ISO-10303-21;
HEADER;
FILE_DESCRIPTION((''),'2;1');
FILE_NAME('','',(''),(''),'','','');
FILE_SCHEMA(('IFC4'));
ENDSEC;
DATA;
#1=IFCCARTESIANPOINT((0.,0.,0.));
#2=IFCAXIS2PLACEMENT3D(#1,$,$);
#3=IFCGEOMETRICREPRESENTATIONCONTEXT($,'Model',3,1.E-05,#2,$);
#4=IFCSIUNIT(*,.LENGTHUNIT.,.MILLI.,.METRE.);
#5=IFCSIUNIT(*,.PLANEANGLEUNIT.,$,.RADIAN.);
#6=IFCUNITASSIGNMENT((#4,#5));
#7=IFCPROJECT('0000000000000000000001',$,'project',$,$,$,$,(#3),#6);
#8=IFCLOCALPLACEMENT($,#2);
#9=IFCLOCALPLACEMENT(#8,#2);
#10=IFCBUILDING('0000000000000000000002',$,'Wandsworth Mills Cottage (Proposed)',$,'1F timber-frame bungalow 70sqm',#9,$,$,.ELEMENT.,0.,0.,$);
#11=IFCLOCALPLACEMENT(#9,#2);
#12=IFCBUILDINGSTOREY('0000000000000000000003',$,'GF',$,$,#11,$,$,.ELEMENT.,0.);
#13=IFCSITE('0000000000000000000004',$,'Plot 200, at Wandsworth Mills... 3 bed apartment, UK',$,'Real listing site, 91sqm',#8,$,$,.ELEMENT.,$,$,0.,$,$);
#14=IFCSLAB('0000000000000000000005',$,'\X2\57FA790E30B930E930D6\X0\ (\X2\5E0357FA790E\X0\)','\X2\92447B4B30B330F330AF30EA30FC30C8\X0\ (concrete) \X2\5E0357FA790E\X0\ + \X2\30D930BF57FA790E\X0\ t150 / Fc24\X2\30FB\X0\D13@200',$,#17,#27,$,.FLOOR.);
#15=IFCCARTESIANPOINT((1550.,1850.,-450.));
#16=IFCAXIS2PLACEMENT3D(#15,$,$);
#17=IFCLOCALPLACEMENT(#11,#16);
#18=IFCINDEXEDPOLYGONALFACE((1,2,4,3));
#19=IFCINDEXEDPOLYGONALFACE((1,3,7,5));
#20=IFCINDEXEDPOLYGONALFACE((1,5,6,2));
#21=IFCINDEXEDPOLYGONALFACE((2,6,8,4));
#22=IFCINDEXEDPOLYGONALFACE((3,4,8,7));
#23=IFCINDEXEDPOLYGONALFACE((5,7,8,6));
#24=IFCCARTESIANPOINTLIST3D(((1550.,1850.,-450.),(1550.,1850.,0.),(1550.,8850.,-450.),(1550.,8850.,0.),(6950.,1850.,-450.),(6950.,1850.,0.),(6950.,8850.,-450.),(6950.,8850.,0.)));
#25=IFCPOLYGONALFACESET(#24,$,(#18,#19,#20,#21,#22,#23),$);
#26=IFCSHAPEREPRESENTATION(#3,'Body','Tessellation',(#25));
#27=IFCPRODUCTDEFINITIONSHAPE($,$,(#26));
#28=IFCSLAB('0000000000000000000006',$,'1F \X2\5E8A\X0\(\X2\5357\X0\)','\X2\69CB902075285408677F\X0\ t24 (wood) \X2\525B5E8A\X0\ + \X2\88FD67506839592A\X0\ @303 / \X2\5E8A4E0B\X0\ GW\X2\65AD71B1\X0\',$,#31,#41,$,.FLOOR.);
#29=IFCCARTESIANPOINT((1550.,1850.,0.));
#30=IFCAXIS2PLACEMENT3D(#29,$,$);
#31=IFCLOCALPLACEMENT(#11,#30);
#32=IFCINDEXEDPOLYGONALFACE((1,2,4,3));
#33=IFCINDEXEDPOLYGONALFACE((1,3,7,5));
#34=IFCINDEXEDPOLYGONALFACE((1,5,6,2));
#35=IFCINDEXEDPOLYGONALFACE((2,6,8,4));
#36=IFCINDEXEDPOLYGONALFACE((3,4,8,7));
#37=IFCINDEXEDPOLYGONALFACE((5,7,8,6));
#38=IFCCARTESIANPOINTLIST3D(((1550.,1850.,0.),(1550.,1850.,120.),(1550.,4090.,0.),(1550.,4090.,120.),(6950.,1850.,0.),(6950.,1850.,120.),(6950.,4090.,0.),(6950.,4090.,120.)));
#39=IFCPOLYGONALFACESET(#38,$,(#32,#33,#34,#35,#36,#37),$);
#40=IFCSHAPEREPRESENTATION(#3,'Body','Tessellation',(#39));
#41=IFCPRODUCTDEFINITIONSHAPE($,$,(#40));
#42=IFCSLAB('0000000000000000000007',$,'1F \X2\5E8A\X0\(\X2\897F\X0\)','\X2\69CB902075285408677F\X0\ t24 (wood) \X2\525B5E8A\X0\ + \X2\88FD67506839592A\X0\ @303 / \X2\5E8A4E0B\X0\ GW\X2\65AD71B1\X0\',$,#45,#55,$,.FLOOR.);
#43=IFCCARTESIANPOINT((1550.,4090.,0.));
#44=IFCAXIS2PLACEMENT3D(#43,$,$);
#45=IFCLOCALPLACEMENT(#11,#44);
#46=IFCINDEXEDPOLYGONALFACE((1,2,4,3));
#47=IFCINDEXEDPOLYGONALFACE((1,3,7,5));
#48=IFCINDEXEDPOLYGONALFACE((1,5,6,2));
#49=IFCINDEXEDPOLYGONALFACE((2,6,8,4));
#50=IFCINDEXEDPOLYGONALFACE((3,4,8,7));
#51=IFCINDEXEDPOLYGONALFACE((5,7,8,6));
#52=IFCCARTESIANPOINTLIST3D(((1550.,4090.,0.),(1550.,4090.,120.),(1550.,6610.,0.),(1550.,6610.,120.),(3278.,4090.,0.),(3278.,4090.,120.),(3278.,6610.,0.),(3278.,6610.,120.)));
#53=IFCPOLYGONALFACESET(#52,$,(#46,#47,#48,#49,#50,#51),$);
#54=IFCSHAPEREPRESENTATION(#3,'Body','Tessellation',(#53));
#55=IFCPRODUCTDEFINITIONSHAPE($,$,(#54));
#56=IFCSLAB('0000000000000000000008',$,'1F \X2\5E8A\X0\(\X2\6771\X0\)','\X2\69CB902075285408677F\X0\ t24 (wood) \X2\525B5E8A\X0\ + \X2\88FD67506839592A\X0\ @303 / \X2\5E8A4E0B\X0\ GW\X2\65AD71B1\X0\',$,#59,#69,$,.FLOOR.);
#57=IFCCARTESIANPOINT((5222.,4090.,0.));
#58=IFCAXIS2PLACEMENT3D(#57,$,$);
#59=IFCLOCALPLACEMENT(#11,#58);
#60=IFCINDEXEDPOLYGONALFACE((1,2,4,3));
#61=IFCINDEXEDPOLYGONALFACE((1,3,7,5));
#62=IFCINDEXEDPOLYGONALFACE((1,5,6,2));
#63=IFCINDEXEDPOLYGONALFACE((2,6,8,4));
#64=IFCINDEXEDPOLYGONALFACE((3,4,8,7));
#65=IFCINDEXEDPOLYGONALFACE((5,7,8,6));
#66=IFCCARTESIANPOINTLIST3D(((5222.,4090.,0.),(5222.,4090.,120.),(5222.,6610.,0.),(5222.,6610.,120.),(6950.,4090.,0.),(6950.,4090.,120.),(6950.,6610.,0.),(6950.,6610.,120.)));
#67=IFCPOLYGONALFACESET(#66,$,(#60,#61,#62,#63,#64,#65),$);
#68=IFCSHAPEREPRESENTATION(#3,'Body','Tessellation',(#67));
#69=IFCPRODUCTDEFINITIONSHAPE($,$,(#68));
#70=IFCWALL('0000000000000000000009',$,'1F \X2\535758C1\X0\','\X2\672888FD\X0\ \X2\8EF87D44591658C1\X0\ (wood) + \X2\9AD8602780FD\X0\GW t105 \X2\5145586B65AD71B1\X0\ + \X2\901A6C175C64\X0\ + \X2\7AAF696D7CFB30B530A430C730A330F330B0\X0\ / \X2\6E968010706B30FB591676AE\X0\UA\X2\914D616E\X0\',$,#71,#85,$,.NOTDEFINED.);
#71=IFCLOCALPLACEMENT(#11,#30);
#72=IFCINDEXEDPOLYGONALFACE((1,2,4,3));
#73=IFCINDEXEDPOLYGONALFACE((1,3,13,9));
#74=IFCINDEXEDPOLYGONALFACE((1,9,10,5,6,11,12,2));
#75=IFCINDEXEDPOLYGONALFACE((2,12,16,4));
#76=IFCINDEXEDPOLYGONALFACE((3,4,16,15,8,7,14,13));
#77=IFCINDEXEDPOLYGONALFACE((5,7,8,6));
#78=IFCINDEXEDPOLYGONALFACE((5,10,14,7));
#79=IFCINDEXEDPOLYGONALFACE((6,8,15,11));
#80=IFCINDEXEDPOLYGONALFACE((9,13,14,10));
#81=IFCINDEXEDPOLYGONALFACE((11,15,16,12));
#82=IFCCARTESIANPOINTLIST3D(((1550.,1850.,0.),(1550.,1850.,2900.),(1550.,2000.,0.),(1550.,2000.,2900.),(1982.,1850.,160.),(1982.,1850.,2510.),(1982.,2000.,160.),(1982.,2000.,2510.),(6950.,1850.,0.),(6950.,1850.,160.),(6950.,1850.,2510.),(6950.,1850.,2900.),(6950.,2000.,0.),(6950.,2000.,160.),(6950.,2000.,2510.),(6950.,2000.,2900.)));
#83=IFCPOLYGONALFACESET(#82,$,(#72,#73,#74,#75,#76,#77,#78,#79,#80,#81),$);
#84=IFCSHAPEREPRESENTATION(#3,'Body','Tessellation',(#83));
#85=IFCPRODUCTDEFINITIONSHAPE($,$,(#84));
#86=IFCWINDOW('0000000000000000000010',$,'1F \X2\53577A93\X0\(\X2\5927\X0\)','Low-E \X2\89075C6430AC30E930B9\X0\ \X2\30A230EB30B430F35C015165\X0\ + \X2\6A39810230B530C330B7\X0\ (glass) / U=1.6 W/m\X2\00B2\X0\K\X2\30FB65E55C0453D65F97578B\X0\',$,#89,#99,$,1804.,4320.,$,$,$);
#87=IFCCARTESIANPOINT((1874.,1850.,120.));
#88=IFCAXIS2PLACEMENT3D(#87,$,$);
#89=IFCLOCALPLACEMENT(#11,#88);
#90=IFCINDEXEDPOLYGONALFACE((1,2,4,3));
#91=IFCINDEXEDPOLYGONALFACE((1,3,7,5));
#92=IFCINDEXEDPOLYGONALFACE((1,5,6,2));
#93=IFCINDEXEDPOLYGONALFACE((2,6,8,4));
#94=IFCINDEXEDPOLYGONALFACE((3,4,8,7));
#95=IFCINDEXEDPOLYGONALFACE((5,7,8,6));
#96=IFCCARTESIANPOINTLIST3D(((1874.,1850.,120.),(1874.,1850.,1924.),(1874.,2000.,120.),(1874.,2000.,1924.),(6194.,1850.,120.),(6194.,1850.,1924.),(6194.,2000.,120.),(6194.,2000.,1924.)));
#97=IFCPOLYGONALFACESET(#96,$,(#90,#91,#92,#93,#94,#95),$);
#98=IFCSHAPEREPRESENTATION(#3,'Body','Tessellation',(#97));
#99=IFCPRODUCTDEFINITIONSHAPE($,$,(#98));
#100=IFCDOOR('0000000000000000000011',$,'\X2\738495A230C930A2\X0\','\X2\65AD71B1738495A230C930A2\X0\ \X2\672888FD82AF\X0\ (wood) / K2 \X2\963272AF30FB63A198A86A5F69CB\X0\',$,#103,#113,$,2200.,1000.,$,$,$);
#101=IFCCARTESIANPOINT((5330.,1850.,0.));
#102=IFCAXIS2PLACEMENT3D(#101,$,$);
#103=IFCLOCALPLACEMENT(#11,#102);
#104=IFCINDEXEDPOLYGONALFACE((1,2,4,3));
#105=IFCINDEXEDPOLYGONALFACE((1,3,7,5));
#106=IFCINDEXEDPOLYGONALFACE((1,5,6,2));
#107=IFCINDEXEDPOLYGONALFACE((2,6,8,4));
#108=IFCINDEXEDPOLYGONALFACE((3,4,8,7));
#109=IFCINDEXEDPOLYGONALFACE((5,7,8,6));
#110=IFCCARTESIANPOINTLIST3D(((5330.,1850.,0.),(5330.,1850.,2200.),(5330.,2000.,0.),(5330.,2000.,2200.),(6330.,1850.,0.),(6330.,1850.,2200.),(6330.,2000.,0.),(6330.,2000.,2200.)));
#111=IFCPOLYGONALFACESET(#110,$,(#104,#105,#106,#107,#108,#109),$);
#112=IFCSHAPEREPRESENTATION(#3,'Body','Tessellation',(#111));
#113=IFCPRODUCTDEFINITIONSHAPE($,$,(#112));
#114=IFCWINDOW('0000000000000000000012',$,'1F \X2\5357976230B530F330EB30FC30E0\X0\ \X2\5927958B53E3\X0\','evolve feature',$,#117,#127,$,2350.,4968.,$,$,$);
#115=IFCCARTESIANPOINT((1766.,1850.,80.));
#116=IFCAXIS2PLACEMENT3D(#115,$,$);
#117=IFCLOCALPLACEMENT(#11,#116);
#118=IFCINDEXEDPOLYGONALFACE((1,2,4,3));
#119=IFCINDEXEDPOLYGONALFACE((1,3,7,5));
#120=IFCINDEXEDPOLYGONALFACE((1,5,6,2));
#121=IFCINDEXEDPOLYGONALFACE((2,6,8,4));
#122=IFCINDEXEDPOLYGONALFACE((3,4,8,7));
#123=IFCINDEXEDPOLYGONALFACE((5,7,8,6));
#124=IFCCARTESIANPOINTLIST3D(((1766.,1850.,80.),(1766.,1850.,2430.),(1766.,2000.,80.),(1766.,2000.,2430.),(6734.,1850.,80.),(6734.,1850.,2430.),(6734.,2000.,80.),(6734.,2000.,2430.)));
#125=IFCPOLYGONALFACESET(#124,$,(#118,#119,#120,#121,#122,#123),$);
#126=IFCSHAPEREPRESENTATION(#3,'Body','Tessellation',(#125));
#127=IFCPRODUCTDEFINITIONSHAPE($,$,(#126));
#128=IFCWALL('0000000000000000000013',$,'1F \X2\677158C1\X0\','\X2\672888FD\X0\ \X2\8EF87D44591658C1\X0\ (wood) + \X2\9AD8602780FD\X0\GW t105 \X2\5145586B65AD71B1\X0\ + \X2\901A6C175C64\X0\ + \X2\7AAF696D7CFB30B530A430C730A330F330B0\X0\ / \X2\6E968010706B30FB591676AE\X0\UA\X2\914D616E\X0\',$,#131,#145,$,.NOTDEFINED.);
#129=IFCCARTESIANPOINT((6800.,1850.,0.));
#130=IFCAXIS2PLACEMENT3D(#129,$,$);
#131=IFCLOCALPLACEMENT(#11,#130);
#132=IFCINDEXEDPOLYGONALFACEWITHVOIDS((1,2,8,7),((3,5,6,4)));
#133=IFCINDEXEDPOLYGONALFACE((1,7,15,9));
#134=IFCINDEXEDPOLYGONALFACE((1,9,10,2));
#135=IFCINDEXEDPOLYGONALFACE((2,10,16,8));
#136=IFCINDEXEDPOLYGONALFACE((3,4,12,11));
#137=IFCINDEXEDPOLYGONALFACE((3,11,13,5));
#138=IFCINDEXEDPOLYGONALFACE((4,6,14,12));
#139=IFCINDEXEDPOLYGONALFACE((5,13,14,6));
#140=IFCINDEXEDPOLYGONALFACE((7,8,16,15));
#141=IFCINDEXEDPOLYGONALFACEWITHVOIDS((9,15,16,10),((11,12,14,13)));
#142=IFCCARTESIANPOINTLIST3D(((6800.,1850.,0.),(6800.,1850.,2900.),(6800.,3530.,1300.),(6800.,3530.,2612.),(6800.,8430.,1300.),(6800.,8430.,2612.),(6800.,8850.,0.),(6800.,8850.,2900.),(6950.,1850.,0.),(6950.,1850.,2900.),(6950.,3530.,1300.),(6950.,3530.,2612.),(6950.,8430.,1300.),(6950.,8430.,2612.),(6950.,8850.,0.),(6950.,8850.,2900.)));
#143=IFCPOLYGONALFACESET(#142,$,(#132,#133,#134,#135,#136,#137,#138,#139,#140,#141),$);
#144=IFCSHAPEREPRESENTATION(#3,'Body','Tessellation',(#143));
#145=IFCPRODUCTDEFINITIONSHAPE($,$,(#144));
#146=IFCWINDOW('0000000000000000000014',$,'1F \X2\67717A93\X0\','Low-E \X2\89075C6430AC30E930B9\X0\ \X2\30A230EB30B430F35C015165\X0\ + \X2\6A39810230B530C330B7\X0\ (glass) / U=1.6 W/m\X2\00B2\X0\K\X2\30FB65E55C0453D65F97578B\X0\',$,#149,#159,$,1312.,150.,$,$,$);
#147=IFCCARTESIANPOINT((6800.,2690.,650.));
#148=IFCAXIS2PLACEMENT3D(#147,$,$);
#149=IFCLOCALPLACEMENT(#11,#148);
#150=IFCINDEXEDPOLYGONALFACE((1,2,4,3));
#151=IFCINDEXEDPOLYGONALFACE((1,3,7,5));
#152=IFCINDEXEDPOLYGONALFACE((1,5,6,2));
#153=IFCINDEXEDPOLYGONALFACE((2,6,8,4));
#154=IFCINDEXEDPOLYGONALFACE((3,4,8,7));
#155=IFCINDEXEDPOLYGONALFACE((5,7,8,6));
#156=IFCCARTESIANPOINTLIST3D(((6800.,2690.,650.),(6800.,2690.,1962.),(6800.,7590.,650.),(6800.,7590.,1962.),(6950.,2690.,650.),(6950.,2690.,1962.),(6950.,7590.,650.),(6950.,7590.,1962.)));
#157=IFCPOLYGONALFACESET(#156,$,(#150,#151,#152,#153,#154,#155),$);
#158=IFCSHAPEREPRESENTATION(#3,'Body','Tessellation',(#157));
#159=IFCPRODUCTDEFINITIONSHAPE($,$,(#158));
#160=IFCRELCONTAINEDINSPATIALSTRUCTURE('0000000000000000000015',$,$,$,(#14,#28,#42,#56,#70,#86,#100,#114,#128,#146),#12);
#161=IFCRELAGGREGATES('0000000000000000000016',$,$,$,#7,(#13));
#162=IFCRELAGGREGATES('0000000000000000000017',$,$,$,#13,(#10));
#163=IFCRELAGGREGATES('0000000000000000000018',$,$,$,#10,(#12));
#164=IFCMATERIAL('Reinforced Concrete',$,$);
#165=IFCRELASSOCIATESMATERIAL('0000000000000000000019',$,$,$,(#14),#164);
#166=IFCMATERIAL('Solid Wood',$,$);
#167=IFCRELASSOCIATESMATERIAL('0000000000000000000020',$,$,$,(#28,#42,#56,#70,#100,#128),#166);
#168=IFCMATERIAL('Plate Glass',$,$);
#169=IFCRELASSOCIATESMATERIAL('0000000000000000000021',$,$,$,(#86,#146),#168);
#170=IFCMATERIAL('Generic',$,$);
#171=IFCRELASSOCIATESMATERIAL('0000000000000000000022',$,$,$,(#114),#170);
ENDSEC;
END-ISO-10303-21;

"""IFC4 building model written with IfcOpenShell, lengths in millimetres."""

from ifc_helpers import new_model, si_unit, frame, frame_2d, origin, place, context, project, spatial, rectangle, extrude, material, element, fill, save


model = new_model("IFC4")

# Units and contexts
model_context = context("Model", 3, precision=1e-05, world=origin())
ifc_project = project(units=[si_unit("LENGTHUNIT", "METRE", prefix="MILLI"), si_unit("PLANEANGLEUNIT", "RADIAN")], contexts=[model_context])

# Site, building, storey
site_placement = place(None, origin())
site = spatial("IfcSite", under=ifc_project, at=site_placement, Name="Plot 200, at Wandsworth Mills... 3 bed apartment, UK", ObjectType="Real listing site, 91sqm", CompositionType="ELEMENT", RefElevation=0.0)
building_placement = place(site_placement, origin())
building = spatial("IfcBuilding", under=site, at=building_placement, Name="Wandsworth Mills Cottage (Proposed)", ObjectType="1F timber-frame bungalow 70sqm", CompositionType="ELEMENT", ElevationOfRefHeight=0.0, ElevationOfTerrain=0.0)
storey_placement = place(building_placement, origin())
storey = spatial("IfcBuildingStorey", under=building, at=storey_placement, Name="GF", CompositionType="ELEMENT", Elevation=0.0)

# Slabs
ifc_material_1 = material(Name="Reinforced Concrete")
slab_1_placement = place(storey_placement, frame((1550.0, 1850.0, -450.0)))
element("IfcSlab", 1, at=slab_1_placement, inside=storey, material=ifc_material_1, Name="基礎スラブ (布基礎)", Description="鉄筋コンクリート (concrete) 布基礎 + ベタ基礎 t150 / Fc24・D13@200", PredefinedType="FLOOR", context=model_context, shape_type="SweptSolid", body=[
    extrude(rectangle(XDim=5400.0, YDim=7000.0, at=frame_2d((2700.0, 3500.0))), frame((1550.0, 1850.0, -450.0)), (0.0, 0.0, 1.0), 450.0),
])
ifc_material_2 = material(Name="Solid Wood")
slab_2_placement = place(storey_placement, frame((1550.0, 1850.0, 0.0)))
element("IfcSlab", 2, at=slab_2_placement, inside=storey, material=ifc_material_2, Name="1F 床(南)", Description="構造用合板 t24 (wood) 剛床 + 製材根太 @303 / 床下 GW断熱", PredefinedType="FLOOR", context=model_context, shape_type="SweptSolid", body=[
    extrude(rectangle(XDim=5400.0, YDim=2240.0, at=frame_2d((2700.0, 1120.0))), frame((1550.0, 1850.0, 0.0)), (0.0, 0.0, 1.0), 120.0),
])
slab_3_placement = place(storey_placement, frame((1550.0, 4090.0, 0.0)))
element("IfcSlab", 3, at=slab_3_placement, inside=storey, material=ifc_material_2, Name="1F 床(西)", Description="構造用合板 t24 (wood) 剛床 + 製材根太 @303 / 床下 GW断熱", PredefinedType="FLOOR", context=model_context, shape_type="SweptSolid", body=[
    extrude(rectangle(XDim=1728.0, YDim=2520.0, at=frame_2d((864.0, 1260.0))), frame((1550.0, 4090.0, 0.0)), (0.0, 0.0, 1.0), 120.0),
])
slab_4_placement = place(storey_placement, frame((5222.0, 4090.0, 0.0)))
element("IfcSlab", 4, at=slab_4_placement, inside=storey, material=ifc_material_2, Name="1F 床(東)", Description="構造用合板 t24 (wood) 剛床 + 製材根太 @303 / 床下 GW断熱", PredefinedType="FLOOR", context=model_context, shape_type="SweptSolid", body=[
    extrude(rectangle(XDim=1728.0, YDim=2520.0, at=frame_2d((864.0, 1260.0))), frame((5222.0, 4090.0, 0.0)), (0.0, 0.0, 1.0), 120.0),
])

# Wall, openings, windows, door
wall_1_placement = place(storey_placement, frame((1550.0, 1850.0, 0.0)))
wall_1 = element("IfcWall", 5, at=wall_1_placement, inside=storey, material=ifc_material_2, Name="1F 南壁", Description="木製 軸組外壁 (wood) + 高性能GW t105 充填断熱 + 通気層 + 窯業系サイディング / 準耐火・外皮UA配慮", PredefinedType="NOTDEFINED", context=model_context, shape_type="SweptSolid", body=[
    extrude(rectangle(XDim=5400.0, YDim=150.0, at=frame_2d((2700.0, 75.0))), frame((1550.0, 1850.0, 0.0)), (0.0, 0.0, 1.0), 2900.0),
])
opening_1_placement = place(storey_placement, frame((1874.0, 1850.0, 120.0)))
opening_1 = element("IfcOpeningElement", 6, at=opening_1_placement, cuts=wall_1, PredefinedType="NOTDEFINED", context=model_context, shape_type="SweptSolid", body=[
    extrude(rectangle(XDim=4320.0, YDim=150.0, at=frame_2d((2160.0, 75.0))), frame((1874.0, 1850.0, 120.0)), (0.0, 0.0, 1.0), 1804.0),
])
opening_2_placement = place(storey_placement, frame((5330.0, 1850.0, 0.0)))
opening_2 = element("IfcOpeningElement", 7, at=opening_2_placement, cuts=wall_1, PredefinedType="NOTDEFINED", context=model_context, shape_type="SweptSolid", body=[
    extrude(rectangle(XDim=1000.0, YDim=150.0, at=frame_2d((500.0, 75.0))), frame((5330.0, 1850.0, 0.0)), (0.0, 0.0, 1.0), 2200.0),
])
opening_3_placement = place(storey_placement, frame((1766.0, 1850.0, 80.0)))
opening_3 = element("IfcOpeningElement", 8, at=opening_3_placement, cuts=wall_1, PredefinedType="NOTDEFINED", context=model_context, shape_type="SweptSolid", body=[
    extrude(rectangle(XDim=4968.0, YDim=150.0, at=frame_2d((2484.0, 75.0))), frame((1766.0, 1850.0, 80.0)), (0.0, 0.0, 1.0), 2350.0),
])
ifc_material_3 = material(Name="Plate Glass")
window_1_placement = place(storey_placement, frame((1874.0, 1850.0, 120.0)))
window_1 = element("IfcWindow", 9, at=window_1_placement, inside=storey, material=ifc_material_3, Name="1F 南窓(大)", Description="Low-E 複層ガラス アルゴン封入 + 樹脂サッシ (glass) / U=1.6 W/m²K・日射取得型", OverallHeight=1804.0, OverallWidth=4320.0, context=model_context, shape_type="SweptSolid", body=[
    extrude(rectangle(XDim=4320.0, YDim=150.0, at=frame_2d((2160.0, 75.0))), frame((1874.0, 1850.0, 120.0)), (0.0, 0.0, 1.0), 1804.0),
])
fill(opening_1, window_1)
door_placement = place(storey_placement, frame((5330.0, 1850.0, 0.0)))
door = element("IfcDoor", 10, at=door_placement, inside=storey, material=ifc_material_2, Name="玄関ドア", Description="断熱玄関ドア 木製芯 (wood) / K2 防犯・採風機構", OverallHeight=2200.0, OverallWidth=1000.0, context=model_context, shape_type="SweptSolid", body=[
    extrude(rectangle(XDim=1000.0, YDim=150.0, at=frame_2d((500.0, 75.0))), frame((5330.0, 1850.0, 0.0)), (0.0, 0.0, 1.0), 2200.0),
])
fill(opening_2, door)
ifc_material_4 = material(Name="Generic")
window_2_placement = place(storey_placement, frame((1766.0, 1850.0, 80.0)))
window_2 = element("IfcWindow", 11, at=window_2_placement, inside=storey, material=ifc_material_4, Name="1F 南面サンルーム 大開口", Description="evolve feature", OverallHeight=2350.0, OverallWidth=4968.0, context=model_context, shape_type="SweptSolid", body=[
    extrude(rectangle(XDim=4968.0, YDim=150.0, at=frame_2d((2484.0, 75.0))), frame((1766.0, 1850.0, 80.0)), (0.0, 0.0, 1.0), 2350.0),
])
fill(opening_3, window_2)

# Wall, opening, window
wall_2_placement = place(storey_placement, frame((6800.0, 1850.0, 0.0)))
wall_2 = element("IfcWall", 12, at=wall_2_placement, inside=storey, material=ifc_material_2, Name="1F 東壁", Description="木製 軸組外壁 (wood) + 高性能GW t105 充填断熱 + 通気層 + 窯業系サイディング / 準耐火・外皮UA配慮", PredefinedType="NOTDEFINED", context=model_context, shape_type="SweptSolid", body=[
    extrude(rectangle(XDim=150.0, YDim=7000.0, at=frame_2d((75.0, 3500.0))), frame((6800.0, 1850.0, 0.0)), (0.0, 0.0, 1.0), 2900.0),
])
opening_4_placement = place(storey_placement, frame((6800.0, 2690.0, 650.0)))
opening_4 = element("IfcOpeningElement", 13, at=opening_4_placement, cuts=wall_2, PredefinedType="NOTDEFINED", context=model_context, shape_type="SweptSolid", body=[
    extrude(rectangle(XDim=150.0, YDim=4900.0, at=frame_2d((75.0, 2450.0))), frame((6800.0, 2690.0, 650.0)), (0.0, 0.0, 1.0), 1312.0),
])
window_3_placement = place(storey_placement, frame((6800.0, 2690.0, 650.0)))
window_3 = element("IfcWindow", 14, at=window_3_placement, inside=storey, material=ifc_material_3, Name="1F 東窓", Description="Low-E 複層ガラス アルゴン封入 + 樹脂サッシ (glass) / U=1.6 W/m²K・日射取得型", OverallHeight=1312.0, OverallWidth=150.0, context=model_context, shape_type="SweptSolid", body=[
    extrude(rectangle(XDim=150.0, YDim=4900.0, at=frame_2d((75.0, 2450.0))), frame((6800.0, 2690.0, 650.0)), (0.0, 0.0, 1.0), 1312.0),
])
fill(opening_4, window_3)

save(model, "model.ifc")
